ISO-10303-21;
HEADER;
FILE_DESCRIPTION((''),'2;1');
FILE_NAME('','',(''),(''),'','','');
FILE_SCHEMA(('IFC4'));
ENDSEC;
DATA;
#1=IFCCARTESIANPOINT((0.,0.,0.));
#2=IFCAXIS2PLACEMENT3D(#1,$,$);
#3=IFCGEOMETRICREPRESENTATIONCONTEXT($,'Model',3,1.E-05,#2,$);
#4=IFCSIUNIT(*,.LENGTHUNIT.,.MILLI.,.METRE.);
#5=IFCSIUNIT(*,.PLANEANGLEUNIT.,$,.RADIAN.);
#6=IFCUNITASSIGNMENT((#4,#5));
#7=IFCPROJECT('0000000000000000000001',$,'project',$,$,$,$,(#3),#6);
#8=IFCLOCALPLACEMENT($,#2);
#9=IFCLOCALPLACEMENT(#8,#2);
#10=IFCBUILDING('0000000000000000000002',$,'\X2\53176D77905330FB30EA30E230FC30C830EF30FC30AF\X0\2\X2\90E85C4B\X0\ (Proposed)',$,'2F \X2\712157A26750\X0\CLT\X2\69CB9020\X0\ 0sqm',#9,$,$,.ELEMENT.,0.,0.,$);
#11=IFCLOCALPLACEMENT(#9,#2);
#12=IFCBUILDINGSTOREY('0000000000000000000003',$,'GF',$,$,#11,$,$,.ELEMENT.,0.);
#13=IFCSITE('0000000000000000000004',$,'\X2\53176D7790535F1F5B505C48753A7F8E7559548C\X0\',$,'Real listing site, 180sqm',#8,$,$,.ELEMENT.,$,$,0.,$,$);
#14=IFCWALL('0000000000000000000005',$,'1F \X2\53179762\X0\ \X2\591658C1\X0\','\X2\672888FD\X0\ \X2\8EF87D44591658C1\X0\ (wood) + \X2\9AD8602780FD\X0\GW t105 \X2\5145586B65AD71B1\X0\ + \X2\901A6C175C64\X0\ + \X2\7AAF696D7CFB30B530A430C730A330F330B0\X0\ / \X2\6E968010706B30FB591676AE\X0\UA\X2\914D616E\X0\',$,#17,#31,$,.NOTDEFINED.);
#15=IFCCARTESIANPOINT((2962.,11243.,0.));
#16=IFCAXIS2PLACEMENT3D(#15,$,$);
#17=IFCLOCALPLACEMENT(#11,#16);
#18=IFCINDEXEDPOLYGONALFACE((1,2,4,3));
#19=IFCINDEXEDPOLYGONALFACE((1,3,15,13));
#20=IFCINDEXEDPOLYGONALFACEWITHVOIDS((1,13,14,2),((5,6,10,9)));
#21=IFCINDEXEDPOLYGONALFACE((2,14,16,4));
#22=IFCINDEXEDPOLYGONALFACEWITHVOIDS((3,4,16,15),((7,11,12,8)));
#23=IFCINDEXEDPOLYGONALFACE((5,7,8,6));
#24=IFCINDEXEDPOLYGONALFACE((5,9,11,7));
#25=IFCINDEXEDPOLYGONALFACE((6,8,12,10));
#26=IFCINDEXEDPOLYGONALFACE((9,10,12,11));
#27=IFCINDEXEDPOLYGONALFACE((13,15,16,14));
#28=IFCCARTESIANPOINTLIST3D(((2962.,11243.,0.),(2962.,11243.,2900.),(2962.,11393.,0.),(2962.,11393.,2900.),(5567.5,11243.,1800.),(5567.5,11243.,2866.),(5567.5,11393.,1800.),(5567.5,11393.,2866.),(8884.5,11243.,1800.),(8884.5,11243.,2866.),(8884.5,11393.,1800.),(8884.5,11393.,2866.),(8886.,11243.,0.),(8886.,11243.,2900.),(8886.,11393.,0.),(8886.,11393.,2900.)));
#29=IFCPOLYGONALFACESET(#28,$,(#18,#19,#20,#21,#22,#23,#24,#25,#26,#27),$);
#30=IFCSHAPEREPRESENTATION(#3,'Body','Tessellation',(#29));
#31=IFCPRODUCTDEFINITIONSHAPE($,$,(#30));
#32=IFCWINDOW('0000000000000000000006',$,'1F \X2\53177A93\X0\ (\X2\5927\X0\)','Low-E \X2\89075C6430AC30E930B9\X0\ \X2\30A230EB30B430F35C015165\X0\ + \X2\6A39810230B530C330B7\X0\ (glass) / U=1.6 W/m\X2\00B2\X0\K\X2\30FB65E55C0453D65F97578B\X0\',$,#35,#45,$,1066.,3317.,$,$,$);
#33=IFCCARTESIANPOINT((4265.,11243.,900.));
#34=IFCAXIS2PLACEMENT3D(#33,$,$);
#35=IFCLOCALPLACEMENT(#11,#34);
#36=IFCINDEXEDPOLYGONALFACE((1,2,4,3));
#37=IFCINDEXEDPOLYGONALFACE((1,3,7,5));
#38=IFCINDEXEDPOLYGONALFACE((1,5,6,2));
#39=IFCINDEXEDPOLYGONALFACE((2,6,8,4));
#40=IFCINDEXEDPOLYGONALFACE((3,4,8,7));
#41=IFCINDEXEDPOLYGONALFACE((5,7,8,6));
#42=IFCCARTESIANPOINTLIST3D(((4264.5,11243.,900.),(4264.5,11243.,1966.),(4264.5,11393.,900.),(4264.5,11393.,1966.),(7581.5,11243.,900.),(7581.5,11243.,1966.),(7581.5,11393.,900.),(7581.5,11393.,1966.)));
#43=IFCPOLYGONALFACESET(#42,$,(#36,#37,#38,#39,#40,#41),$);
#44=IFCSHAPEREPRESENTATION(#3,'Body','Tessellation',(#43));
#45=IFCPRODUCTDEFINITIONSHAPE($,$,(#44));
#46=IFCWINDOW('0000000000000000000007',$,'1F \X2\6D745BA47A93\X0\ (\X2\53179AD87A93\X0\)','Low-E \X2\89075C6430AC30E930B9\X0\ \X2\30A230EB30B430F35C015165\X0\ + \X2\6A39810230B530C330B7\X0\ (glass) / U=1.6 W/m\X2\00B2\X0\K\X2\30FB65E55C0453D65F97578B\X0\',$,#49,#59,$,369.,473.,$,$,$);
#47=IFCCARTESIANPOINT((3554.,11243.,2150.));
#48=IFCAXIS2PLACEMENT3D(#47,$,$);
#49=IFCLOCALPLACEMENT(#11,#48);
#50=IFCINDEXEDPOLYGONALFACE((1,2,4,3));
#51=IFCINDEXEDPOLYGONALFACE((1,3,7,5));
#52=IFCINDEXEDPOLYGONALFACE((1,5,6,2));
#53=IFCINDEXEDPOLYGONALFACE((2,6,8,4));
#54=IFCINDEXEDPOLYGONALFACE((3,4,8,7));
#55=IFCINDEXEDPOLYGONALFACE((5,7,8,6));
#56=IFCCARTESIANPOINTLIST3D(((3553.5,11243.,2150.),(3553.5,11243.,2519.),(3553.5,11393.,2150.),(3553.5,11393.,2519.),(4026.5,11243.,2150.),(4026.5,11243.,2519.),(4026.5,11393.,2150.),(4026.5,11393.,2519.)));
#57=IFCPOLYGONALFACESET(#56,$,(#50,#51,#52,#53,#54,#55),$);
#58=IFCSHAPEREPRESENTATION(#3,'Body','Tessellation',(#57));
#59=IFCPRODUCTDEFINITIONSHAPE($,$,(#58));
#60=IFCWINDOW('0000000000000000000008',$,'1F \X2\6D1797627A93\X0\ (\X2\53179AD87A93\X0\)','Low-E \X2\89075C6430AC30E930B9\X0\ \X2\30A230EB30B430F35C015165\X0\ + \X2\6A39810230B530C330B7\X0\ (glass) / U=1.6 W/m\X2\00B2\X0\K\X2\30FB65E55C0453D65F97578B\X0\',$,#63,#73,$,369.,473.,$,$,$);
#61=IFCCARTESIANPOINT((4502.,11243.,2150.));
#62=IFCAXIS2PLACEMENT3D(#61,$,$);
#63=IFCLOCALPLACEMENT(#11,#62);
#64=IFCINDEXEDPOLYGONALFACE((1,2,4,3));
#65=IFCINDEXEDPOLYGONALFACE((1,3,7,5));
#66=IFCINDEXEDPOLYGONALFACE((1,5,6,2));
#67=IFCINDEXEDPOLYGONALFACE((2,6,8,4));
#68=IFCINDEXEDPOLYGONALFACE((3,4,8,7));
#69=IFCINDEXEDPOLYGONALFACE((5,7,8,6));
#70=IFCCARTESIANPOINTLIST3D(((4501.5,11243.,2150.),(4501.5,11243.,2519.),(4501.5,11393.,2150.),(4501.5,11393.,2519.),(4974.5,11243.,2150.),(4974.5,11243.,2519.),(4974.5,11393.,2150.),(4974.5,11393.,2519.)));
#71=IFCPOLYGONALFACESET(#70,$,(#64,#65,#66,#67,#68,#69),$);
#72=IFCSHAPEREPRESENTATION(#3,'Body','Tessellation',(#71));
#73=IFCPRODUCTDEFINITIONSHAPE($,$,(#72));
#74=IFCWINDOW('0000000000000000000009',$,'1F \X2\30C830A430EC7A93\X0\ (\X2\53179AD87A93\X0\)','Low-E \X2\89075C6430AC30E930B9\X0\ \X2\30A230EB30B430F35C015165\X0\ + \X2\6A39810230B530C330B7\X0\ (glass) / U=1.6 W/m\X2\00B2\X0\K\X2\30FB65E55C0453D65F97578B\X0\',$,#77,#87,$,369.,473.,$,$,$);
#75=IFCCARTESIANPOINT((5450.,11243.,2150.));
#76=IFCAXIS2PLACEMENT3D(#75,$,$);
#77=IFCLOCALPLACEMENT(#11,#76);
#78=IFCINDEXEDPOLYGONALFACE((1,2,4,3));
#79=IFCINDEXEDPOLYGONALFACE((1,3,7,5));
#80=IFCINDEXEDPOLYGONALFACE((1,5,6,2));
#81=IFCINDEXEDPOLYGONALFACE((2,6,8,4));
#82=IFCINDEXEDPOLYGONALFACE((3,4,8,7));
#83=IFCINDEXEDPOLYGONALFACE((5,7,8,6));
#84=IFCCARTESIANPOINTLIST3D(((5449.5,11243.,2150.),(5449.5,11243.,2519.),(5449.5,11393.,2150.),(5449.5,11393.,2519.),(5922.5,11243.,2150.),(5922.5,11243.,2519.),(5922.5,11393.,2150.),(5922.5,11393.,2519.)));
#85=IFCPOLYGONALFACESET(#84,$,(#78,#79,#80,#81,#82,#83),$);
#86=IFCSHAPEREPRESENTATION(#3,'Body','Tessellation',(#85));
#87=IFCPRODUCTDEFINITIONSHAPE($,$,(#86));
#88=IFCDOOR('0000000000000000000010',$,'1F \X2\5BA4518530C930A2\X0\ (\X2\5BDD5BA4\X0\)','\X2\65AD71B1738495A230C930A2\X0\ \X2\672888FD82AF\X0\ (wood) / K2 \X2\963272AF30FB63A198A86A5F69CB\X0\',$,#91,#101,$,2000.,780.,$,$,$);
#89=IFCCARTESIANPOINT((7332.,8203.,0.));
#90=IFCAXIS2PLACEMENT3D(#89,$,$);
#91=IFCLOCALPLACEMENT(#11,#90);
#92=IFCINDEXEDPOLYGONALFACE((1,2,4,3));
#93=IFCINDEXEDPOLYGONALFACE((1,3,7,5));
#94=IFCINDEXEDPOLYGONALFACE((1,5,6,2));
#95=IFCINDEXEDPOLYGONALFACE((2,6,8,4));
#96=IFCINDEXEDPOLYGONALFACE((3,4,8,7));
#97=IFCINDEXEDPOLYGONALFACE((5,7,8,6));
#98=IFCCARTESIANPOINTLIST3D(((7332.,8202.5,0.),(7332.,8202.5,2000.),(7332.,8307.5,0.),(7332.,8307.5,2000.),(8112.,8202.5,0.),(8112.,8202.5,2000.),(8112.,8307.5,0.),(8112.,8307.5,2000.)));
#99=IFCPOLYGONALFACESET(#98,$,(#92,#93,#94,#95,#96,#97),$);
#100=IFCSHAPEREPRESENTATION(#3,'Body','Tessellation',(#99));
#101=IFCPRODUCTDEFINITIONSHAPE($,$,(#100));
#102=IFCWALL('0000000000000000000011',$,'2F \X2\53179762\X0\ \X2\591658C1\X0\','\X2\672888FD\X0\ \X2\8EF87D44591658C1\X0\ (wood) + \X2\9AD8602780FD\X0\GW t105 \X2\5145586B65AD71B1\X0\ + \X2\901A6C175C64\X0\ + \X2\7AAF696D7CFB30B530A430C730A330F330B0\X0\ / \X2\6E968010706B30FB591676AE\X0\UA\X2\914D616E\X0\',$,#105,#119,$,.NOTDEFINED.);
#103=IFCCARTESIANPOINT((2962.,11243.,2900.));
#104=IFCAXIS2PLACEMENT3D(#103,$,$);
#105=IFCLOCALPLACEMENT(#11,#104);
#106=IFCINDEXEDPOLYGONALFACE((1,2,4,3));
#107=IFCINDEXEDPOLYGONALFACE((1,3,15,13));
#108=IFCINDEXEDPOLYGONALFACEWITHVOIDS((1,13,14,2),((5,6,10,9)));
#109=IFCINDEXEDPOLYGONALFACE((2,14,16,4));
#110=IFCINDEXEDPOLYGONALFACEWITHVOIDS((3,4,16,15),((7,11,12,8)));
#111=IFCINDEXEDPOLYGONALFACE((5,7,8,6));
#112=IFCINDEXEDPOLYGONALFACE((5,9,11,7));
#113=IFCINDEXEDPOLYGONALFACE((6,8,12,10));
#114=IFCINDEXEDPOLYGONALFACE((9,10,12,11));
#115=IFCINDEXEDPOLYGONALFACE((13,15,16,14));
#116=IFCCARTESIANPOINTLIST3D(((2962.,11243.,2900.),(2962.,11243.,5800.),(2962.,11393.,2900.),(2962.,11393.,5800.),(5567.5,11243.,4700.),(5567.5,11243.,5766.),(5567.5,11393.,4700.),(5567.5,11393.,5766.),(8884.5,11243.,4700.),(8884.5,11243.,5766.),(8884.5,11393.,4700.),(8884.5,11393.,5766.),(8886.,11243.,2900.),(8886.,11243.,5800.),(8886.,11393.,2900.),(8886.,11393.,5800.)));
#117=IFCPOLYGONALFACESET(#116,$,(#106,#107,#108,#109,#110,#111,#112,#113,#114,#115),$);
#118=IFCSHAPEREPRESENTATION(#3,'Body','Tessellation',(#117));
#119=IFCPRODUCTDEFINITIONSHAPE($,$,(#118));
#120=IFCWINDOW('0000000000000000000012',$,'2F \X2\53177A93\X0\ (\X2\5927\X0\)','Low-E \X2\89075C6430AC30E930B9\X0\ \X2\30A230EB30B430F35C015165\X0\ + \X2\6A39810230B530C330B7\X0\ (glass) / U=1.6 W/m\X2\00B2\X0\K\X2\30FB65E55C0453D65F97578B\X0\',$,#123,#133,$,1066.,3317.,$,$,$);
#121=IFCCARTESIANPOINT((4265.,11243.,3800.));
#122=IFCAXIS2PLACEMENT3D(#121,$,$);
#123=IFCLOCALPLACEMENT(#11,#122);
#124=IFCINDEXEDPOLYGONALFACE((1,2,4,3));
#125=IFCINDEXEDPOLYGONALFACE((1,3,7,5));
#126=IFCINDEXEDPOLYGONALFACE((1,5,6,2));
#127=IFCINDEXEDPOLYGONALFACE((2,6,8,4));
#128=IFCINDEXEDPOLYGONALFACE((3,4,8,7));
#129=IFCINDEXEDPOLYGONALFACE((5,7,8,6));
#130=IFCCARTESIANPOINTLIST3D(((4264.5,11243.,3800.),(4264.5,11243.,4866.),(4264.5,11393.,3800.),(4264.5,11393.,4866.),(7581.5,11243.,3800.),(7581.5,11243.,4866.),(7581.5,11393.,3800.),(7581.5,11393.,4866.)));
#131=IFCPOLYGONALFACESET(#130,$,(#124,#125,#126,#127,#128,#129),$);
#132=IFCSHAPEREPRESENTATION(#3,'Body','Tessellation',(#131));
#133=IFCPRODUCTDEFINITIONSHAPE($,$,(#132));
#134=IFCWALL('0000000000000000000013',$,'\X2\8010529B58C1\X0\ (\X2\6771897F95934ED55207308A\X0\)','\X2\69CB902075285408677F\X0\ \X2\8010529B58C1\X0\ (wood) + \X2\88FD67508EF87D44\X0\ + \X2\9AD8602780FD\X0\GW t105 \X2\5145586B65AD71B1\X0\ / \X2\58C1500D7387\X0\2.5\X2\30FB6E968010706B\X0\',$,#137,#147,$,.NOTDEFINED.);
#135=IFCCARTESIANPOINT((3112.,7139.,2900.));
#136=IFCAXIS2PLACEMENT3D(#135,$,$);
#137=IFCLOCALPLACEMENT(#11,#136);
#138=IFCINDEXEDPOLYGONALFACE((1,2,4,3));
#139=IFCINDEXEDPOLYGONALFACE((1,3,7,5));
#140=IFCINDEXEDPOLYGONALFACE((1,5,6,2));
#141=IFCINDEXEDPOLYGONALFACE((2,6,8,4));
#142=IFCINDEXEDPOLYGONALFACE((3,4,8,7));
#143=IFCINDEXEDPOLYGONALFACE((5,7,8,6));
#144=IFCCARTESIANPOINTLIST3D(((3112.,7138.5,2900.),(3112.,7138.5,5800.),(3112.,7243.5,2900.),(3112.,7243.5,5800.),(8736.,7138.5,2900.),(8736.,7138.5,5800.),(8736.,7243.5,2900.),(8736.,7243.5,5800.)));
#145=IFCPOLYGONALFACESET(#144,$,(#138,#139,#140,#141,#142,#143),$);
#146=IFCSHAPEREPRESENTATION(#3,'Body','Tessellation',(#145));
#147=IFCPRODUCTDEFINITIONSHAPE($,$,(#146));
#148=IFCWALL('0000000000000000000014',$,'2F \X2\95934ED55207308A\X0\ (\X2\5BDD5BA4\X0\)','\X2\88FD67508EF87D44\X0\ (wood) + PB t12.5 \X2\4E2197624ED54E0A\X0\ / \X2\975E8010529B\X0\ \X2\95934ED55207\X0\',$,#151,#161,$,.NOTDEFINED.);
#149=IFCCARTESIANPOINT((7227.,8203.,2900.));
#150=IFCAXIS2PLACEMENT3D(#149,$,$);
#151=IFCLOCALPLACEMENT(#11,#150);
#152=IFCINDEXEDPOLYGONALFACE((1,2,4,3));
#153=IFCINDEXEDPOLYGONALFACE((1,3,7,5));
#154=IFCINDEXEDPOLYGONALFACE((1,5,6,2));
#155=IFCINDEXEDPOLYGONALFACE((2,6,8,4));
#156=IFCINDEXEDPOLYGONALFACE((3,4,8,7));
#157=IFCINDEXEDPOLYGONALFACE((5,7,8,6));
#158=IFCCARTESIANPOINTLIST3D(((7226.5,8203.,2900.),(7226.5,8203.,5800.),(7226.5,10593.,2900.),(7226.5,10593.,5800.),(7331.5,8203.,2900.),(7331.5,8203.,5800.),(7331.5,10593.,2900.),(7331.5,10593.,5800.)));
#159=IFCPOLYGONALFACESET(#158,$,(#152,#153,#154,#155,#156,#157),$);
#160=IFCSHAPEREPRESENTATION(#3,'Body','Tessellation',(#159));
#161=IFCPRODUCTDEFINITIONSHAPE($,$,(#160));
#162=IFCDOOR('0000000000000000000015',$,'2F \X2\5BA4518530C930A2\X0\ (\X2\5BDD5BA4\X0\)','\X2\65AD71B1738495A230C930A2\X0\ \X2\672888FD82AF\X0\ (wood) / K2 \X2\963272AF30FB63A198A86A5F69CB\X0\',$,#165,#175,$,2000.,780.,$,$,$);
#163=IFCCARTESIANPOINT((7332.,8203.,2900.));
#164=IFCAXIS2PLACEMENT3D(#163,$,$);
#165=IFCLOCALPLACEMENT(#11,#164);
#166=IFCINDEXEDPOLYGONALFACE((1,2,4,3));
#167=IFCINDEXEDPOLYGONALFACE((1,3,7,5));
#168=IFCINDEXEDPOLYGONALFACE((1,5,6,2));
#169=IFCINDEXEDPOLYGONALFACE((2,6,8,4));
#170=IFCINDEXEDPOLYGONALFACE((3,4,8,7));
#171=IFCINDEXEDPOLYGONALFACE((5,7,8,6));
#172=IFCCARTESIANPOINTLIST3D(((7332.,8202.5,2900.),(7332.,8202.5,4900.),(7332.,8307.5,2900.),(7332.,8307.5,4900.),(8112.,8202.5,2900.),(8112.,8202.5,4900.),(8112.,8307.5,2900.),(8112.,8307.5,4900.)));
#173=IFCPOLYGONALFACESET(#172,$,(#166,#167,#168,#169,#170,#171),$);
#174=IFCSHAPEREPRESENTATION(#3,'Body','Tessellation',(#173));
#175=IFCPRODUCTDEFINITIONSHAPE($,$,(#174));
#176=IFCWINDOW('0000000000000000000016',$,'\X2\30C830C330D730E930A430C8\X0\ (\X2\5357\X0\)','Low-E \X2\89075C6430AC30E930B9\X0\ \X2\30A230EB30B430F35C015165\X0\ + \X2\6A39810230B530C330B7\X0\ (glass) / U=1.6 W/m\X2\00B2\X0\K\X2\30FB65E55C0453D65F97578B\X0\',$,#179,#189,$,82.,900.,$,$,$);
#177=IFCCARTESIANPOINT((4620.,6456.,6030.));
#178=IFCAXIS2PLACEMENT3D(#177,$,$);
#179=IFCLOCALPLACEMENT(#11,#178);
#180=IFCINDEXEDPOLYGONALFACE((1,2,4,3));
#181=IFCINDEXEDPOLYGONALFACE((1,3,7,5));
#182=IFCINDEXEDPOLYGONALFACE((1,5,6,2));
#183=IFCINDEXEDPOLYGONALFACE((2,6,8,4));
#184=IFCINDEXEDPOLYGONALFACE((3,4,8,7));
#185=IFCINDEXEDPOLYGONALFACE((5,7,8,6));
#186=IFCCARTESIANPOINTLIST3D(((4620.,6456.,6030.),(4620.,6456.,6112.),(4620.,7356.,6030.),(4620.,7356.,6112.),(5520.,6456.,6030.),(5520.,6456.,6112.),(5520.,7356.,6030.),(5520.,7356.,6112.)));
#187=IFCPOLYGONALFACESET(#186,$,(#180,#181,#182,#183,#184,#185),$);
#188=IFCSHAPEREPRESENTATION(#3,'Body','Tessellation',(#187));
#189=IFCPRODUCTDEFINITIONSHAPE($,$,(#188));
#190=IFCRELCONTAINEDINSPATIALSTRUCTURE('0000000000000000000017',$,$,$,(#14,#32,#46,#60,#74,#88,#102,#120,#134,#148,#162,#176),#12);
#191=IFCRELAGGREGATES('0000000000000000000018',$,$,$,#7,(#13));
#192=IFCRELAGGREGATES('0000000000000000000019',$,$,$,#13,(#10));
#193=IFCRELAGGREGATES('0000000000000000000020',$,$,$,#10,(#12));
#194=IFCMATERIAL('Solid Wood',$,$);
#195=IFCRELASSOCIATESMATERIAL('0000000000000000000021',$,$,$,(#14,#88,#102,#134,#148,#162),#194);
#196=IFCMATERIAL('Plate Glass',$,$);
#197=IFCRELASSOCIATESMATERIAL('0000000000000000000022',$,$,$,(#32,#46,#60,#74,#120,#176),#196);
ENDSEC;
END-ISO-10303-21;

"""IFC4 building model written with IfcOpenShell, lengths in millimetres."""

from ifc_helpers import new_model, si_unit, frame, frame_2d, origin, place, context, project, spatial, rectangle, extrude, material, element, fill, save


model = new_model("IFC4")

# Units and contexts
model_context = context("Model", 3, precision=1e-05, world=origin())
ifc_project = project(units=[si_unit("LENGTHUNIT", "METRE", prefix="MILLI"), si_unit("PLANEANGLEUNIT", "RADIAN")], contexts=[model_context])

# Site, building, storey
site_placement = place(None, origin())
site = spatial("IfcSite", under=ifc_project, at=site_placement, Name="北海道弟子屈町美留和", ObjectType="Real listing site, 180sqm", CompositionType="ELEMENT", RefElevation=0.0)
building_placement = place(site_placement, origin())
building = spatial("IfcBuilding", under=site, at=building_placement, Name="北海道・リモートワーク2部屋 (Proposed)", ObjectType="2F 無垢材CLT構造 0sqm", CompositionType="ELEMENT", ElevationOfRefHeight=0.0, ElevationOfTerrain=0.0)
storey_placement = place(building_placement, origin())
storey = spatial("IfcBuildingStorey", under=building, at=storey_placement, Name="GF", CompositionType="ELEMENT", Elevation=0.0)

# Wall, openings, windows
ifc_material_1 = material(Name="Solid Wood")
wall_1_placement = place(storey_placement, frame((2962.0, 11243.0, 0.0)))
wall_1 = element("IfcWall", 1, at=wall_1_placement, inside=storey, material=ifc_material_1, Name="1F 北面 外壁", Description="木製 軸組外壁 (wood) + 高性能GW t105 充填断熱 + 通気層 + 窯業系サイディング / 準耐火・外皮UA配慮", PredefinedType="NOTDEFINED", context=model_context, shape_type="SweptSolid", body=[
    extrude(rectangle(XDim=5924.0, YDim=150.0, at=frame_2d((2962.0, 75.0))), frame((2962.0, 11243.0, 0.0)), (0.0, 0.0, 1.0), 2900.0),
])
opening_1_placement = place(storey_placement, frame((4265.0, 11243.0, 900.0)))
opening_1 = element("IfcOpeningElement", 2, at=opening_1_placement, cuts=wall_1, PredefinedType="NOTDEFINED", context=model_context, shape_type="SweptSolid", body=[
    extrude(rectangle(XDim=3317.0, YDim=150.0, at=frame_2d((1658.0, 75.0))), frame((4265.0, 11243.0, 900.0)), (0.0, 0.0, 1.0), 1066.0),
])
opening_2_placement = place(storey_placement, frame((3554.0, 11243.0, 2150.0)))
opening_2 = element("IfcOpeningElement", 3, at=opening_2_placement, cuts=wall_1, PredefinedType="NOTDEFINED", context=model_context, shape_type="SweptSolid", body=[
    extrude(rectangle(XDim=473.0, YDim=150.0, at=frame_2d((236.0, 75.0))), frame((3554.0, 11243.0, 2150.0)), (0.0, 0.0, 1.0), 369.0),
])
opening_3_placement = place(storey_placement, frame((4502.0, 11243.0, 2150.0)))
opening_3 = element("IfcOpeningElement", 4, at=opening_3_placement, cuts=wall_1, PredefinedType="NOTDEFINED", context=model_context, shape_type="SweptSolid", body=[
    extrude(rectangle(XDim=473.0, YDim=150.0, at=frame_2d((236.0, 75.0))), frame((4502.0, 11243.0, 2150.0)), (0.0, 0.0, 1.0), 369.0),
])
opening_4_placement = place(storey_placement, frame((5450.0, 11243.0, 2150.0)))
opening_4 = element("IfcOpeningElement", 5, at=opening_4_placement, cuts=wall_1, PredefinedType="NOTDEFINED", context=model_context, shape_type="SweptSolid", body=[
    extrude(rectangle(XDim=473.0, YDim=150.0, at=frame_2d((236.0, 75.0))), frame((5450.0, 11243.0, 2150.0)), (0.0, 0.0, 1.0), 369.0),
])
ifc_material_2 = material(Name="Plate Glass")
window_1_placement = place(storey_placement, frame((4265.0, 11243.0, 900.0)))
window_1 = element("IfcWindow", 6, at=window_1_placement, inside=storey, material=ifc_material_2, Name="1F 北窓 (大)", Description="Low-E 複層ガラス アルゴン封入 + 樹脂サッシ (glass) / U=1.6 W/m²K・日射取得型", OverallHeight=1066.0, OverallWidth=3317.0, context=model_context, shape_type="SweptSolid", body=[
    extrude(rectangle(XDim=3317.0, YDim=150.0, at=frame_2d((1658.0, 75.0))), frame((4265.0, 11243.0, 900.0)), (0.0, 0.0, 1.0), 1066.0),
])
fill(opening_1, window_1)
window_2_placement = place(storey_placement, frame((3554.0, 11243.0, 2150.0)))
window_2 = element("IfcWindow", 7, at=window_2_placement, inside=storey, material=ifc_material_2, Name="1F 浴室窓 (北高窓)", Description="Low-E 複層ガラス アルゴン封入 + 樹脂サッシ (glass) / U=1.6 W/m²K・日射取得型", OverallHeight=369.0, OverallWidth=473.0, context=model_context, shape_type="SweptSolid", body=[
    extrude(rectangle(XDim=473.0, YDim=150.0, at=frame_2d((236.0, 75.0))), frame((3554.0, 11243.0, 2150.0)), (0.0, 0.0, 1.0), 369.0),
])
fill(opening_2, window_2)
window_3_placement = place(storey_placement, frame((4502.0, 11243.0, 2150.0)))
window_3 = element("IfcWindow", 8, at=window_3_placement, inside=storey, material=ifc_material_2, Name="1F 洗面窓 (北高窓)", Description="Low-E 複層ガラス アルゴン封入 + 樹脂サッシ (glass) / U=1.6 W/m²K・日射取得型", OverallHeight=369.0, OverallWidth=473.0, context=model_context, shape_type="SweptSolid", body=[
    extrude(rectangle(XDim=473.0, YDim=150.0, at=frame_2d((236.0, 75.0))), frame((4502.0, 11243.0, 2150.0)), (0.0, 0.0, 1.0), 369.0),
])
fill(opening_3, window_3)
window_4_placement = place(storey_placement, frame((5450.0, 11243.0, 2150.0)))
window_4 = element("IfcWindow", 9, at=window_4_placement, inside=storey, material=ifc_material_2, Name="1F トイレ窓 (北高窓)", Description="Low-E 複層ガラス アルゴン封入 + 樹脂サッシ (glass) / U=1.6 W/m²K・日射取得型", OverallHeight=369.0, OverallWidth=473.0, context=model_context, shape_type="SweptSolid", body=[
    extrude(rectangle(XDim=473.0, YDim=150.0, at=frame_2d((236.0, 75.0))), frame((5450.0, 11243.0, 2150.0)), (0.0, 0.0, 1.0), 369.0),
])
fill(opening_4, window_4)

# Door
door_1_placement = place(storey_placement, frame((7332.0, 8203.0, 0.0)))
element("IfcDoor", 10, at=door_1_placement, inside=storey, material=ifc_material_1, Name="1F 室内ドア (寝室)", Description="断熱玄関ドア 木製芯 (wood) / K2 防犯・採風機構", OverallHeight=2000.0, OverallWidth=780.0, context=model_context, shape_type="SweptSolid", body=[
    extrude(rectangle(XDim=780.0, YDim=105.0, at=frame_2d((390.0, 52.0))), frame((7332.0, 8203.0, 0.0)), (0.0, 0.0, 1.0), 2000.0),
])

# Wall, opening, window
wall_2_placement = place(storey_placement, frame((2962.0, 11243.0, 2900.0)))
wall_2 = element("IfcWall", 11, at=wall_2_placement, inside=storey, material=ifc_material_1, Name="2F 北面 外壁", Description="木製 軸組外壁 (wood) + 高性能GW t105 充填断熱 + 通気層 + 窯業系サイディング / 準耐火・外皮UA配慮", PredefinedType="NOTDEFINED", context=model_context, shape_type="SweptSolid", body=[
    extrude(rectangle(XDim=5924.0, YDim=150.0, at=frame_2d((2962.0, 75.0))), frame((2962.0, 11243.0, 2900.0)), (0.0, 0.0, 1.0), 2900.0),
])
opening_5_placement = place(storey_placement, frame((4265.0, 11243.0, 3800.0)))
opening_5 = element("IfcOpeningElement", 12, at=opening_5_placement, cuts=wall_2, PredefinedType="NOTDEFINED", context=model_context, shape_type="SweptSolid", body=[
    extrude(rectangle(XDim=3317.0, YDim=150.0, at=frame_2d((1658.0, 75.0))), frame((4265.0, 11243.0, 3800.0)), (0.0, 0.0, 1.0), 1066.0),
])
window_5_placement = place(storey_placement, frame((4265.0, 11243.0, 3800.0)))
window_5 = element("IfcWindow", 13, at=window_5_placement, inside=storey, material=ifc_material_2, Name="2F 北窓 (大)", Description="Low-E 複層ガラス アルゴン封入 + 樹脂サッシ (glass) / U=1.6 W/m²K・日射取得型", OverallHeight=1066.0, OverallWidth=3317.0, context=model_context, shape_type="SweptSolid", body=[
    extrude(rectangle(XDim=3317.0, YDim=150.0, at=frame_2d((1658.0, 75.0))), frame((4265.0, 11243.0, 3800.0)), (0.0, 0.0, 1.0), 1066.0),
])
fill(opening_5, window_5)

# Walls
wall_3_placement = place(storey_placement, frame((3112.0, 7139.0, 2900.0)))
element("IfcWall", 14, at=wall_3_placement, inside=storey, material=ifc_material_1, Name="耐力壁 (東西間仕切り)", Description="構造用合板 耐力壁 (wood) + 製材軸組 + 高性能GW t105 充填断熱 / 壁倍率2.5・準耐火", PredefinedType="NOTDEFINED", context=model_context, shape_type="SweptSolid", body=[
    extrude(rectangle(XDim=5624.0, YDim=105.0, at=frame_2d((2812.0, 52.0))), frame((3112.0, 7139.0, 2900.0)), (0.0, 0.0, 1.0), 2900.0),
])
wall_4_placement = place(storey_placement, frame((7227.0, 8203.0, 2900.0)))
element("IfcWall", 15, at=wall_4_placement, inside=storey, material=ifc_material_1, Name="2F 間仕切り (寝室)", Description="製材軸組 (wood) + PB t12.5 両面仕上 / 非耐力 間仕切", PredefinedType="NOTDEFINED", context=model_context, shape_type="SweptSolid", body=[
    extrude(rectangle(XDim=105.0, YDim=2390.0, at=frame_2d((52.0, 1195.0))), frame((7227.0, 8203.0, 2900.0)), (0.0, 0.0, 1.0), 2900.0),
])

# Door
door_2_placement = place(storey_placement, frame((7332.0, 8203.0, 2900.0)))
element("IfcDoor", 16, at=door_2_placement, inside=storey, material=ifc_material_1, Name="2F 室内ドア (寝室)", Description="断熱玄関ドア 木製芯 (wood) / K2 防犯・採風機構", OverallHeight=2000.0, OverallWidth=780.0, context=model_context, shape_type="SweptSolid", body=[
    extrude(rectangle(XDim=780.0, YDim=105.0, at=frame_2d((390.0, 52.0))), frame((7332.0, 8203.0, 2900.0)), (0.0, 0.0, 1.0), 2000.0),
])

# Window
window_6_placement = place(storey_placement, frame((4620.0, 6456.0, 6030.0)))
element("IfcWindow", 17, at=window_6_placement, inside=storey, material=ifc_material_2, Name="トップライト (南)", Description="Low-E 複層ガラス アルゴン封入 + 樹脂サッシ (glass) / U=1.6 W/m²K・日射取得型", OverallHeight=82.0, OverallWidth=900.0, context=model_context, shape_type="SweptSolid", body=[
    extrude(rectangle(XDim=900.0, YDim=900.0, at=frame_2d((450.0, 450.0))), frame((4620.0, 6456.0, 6030.0)), (0.0, 0.0, 1.0), 82.0),
])

save(model, "model.ifc")
